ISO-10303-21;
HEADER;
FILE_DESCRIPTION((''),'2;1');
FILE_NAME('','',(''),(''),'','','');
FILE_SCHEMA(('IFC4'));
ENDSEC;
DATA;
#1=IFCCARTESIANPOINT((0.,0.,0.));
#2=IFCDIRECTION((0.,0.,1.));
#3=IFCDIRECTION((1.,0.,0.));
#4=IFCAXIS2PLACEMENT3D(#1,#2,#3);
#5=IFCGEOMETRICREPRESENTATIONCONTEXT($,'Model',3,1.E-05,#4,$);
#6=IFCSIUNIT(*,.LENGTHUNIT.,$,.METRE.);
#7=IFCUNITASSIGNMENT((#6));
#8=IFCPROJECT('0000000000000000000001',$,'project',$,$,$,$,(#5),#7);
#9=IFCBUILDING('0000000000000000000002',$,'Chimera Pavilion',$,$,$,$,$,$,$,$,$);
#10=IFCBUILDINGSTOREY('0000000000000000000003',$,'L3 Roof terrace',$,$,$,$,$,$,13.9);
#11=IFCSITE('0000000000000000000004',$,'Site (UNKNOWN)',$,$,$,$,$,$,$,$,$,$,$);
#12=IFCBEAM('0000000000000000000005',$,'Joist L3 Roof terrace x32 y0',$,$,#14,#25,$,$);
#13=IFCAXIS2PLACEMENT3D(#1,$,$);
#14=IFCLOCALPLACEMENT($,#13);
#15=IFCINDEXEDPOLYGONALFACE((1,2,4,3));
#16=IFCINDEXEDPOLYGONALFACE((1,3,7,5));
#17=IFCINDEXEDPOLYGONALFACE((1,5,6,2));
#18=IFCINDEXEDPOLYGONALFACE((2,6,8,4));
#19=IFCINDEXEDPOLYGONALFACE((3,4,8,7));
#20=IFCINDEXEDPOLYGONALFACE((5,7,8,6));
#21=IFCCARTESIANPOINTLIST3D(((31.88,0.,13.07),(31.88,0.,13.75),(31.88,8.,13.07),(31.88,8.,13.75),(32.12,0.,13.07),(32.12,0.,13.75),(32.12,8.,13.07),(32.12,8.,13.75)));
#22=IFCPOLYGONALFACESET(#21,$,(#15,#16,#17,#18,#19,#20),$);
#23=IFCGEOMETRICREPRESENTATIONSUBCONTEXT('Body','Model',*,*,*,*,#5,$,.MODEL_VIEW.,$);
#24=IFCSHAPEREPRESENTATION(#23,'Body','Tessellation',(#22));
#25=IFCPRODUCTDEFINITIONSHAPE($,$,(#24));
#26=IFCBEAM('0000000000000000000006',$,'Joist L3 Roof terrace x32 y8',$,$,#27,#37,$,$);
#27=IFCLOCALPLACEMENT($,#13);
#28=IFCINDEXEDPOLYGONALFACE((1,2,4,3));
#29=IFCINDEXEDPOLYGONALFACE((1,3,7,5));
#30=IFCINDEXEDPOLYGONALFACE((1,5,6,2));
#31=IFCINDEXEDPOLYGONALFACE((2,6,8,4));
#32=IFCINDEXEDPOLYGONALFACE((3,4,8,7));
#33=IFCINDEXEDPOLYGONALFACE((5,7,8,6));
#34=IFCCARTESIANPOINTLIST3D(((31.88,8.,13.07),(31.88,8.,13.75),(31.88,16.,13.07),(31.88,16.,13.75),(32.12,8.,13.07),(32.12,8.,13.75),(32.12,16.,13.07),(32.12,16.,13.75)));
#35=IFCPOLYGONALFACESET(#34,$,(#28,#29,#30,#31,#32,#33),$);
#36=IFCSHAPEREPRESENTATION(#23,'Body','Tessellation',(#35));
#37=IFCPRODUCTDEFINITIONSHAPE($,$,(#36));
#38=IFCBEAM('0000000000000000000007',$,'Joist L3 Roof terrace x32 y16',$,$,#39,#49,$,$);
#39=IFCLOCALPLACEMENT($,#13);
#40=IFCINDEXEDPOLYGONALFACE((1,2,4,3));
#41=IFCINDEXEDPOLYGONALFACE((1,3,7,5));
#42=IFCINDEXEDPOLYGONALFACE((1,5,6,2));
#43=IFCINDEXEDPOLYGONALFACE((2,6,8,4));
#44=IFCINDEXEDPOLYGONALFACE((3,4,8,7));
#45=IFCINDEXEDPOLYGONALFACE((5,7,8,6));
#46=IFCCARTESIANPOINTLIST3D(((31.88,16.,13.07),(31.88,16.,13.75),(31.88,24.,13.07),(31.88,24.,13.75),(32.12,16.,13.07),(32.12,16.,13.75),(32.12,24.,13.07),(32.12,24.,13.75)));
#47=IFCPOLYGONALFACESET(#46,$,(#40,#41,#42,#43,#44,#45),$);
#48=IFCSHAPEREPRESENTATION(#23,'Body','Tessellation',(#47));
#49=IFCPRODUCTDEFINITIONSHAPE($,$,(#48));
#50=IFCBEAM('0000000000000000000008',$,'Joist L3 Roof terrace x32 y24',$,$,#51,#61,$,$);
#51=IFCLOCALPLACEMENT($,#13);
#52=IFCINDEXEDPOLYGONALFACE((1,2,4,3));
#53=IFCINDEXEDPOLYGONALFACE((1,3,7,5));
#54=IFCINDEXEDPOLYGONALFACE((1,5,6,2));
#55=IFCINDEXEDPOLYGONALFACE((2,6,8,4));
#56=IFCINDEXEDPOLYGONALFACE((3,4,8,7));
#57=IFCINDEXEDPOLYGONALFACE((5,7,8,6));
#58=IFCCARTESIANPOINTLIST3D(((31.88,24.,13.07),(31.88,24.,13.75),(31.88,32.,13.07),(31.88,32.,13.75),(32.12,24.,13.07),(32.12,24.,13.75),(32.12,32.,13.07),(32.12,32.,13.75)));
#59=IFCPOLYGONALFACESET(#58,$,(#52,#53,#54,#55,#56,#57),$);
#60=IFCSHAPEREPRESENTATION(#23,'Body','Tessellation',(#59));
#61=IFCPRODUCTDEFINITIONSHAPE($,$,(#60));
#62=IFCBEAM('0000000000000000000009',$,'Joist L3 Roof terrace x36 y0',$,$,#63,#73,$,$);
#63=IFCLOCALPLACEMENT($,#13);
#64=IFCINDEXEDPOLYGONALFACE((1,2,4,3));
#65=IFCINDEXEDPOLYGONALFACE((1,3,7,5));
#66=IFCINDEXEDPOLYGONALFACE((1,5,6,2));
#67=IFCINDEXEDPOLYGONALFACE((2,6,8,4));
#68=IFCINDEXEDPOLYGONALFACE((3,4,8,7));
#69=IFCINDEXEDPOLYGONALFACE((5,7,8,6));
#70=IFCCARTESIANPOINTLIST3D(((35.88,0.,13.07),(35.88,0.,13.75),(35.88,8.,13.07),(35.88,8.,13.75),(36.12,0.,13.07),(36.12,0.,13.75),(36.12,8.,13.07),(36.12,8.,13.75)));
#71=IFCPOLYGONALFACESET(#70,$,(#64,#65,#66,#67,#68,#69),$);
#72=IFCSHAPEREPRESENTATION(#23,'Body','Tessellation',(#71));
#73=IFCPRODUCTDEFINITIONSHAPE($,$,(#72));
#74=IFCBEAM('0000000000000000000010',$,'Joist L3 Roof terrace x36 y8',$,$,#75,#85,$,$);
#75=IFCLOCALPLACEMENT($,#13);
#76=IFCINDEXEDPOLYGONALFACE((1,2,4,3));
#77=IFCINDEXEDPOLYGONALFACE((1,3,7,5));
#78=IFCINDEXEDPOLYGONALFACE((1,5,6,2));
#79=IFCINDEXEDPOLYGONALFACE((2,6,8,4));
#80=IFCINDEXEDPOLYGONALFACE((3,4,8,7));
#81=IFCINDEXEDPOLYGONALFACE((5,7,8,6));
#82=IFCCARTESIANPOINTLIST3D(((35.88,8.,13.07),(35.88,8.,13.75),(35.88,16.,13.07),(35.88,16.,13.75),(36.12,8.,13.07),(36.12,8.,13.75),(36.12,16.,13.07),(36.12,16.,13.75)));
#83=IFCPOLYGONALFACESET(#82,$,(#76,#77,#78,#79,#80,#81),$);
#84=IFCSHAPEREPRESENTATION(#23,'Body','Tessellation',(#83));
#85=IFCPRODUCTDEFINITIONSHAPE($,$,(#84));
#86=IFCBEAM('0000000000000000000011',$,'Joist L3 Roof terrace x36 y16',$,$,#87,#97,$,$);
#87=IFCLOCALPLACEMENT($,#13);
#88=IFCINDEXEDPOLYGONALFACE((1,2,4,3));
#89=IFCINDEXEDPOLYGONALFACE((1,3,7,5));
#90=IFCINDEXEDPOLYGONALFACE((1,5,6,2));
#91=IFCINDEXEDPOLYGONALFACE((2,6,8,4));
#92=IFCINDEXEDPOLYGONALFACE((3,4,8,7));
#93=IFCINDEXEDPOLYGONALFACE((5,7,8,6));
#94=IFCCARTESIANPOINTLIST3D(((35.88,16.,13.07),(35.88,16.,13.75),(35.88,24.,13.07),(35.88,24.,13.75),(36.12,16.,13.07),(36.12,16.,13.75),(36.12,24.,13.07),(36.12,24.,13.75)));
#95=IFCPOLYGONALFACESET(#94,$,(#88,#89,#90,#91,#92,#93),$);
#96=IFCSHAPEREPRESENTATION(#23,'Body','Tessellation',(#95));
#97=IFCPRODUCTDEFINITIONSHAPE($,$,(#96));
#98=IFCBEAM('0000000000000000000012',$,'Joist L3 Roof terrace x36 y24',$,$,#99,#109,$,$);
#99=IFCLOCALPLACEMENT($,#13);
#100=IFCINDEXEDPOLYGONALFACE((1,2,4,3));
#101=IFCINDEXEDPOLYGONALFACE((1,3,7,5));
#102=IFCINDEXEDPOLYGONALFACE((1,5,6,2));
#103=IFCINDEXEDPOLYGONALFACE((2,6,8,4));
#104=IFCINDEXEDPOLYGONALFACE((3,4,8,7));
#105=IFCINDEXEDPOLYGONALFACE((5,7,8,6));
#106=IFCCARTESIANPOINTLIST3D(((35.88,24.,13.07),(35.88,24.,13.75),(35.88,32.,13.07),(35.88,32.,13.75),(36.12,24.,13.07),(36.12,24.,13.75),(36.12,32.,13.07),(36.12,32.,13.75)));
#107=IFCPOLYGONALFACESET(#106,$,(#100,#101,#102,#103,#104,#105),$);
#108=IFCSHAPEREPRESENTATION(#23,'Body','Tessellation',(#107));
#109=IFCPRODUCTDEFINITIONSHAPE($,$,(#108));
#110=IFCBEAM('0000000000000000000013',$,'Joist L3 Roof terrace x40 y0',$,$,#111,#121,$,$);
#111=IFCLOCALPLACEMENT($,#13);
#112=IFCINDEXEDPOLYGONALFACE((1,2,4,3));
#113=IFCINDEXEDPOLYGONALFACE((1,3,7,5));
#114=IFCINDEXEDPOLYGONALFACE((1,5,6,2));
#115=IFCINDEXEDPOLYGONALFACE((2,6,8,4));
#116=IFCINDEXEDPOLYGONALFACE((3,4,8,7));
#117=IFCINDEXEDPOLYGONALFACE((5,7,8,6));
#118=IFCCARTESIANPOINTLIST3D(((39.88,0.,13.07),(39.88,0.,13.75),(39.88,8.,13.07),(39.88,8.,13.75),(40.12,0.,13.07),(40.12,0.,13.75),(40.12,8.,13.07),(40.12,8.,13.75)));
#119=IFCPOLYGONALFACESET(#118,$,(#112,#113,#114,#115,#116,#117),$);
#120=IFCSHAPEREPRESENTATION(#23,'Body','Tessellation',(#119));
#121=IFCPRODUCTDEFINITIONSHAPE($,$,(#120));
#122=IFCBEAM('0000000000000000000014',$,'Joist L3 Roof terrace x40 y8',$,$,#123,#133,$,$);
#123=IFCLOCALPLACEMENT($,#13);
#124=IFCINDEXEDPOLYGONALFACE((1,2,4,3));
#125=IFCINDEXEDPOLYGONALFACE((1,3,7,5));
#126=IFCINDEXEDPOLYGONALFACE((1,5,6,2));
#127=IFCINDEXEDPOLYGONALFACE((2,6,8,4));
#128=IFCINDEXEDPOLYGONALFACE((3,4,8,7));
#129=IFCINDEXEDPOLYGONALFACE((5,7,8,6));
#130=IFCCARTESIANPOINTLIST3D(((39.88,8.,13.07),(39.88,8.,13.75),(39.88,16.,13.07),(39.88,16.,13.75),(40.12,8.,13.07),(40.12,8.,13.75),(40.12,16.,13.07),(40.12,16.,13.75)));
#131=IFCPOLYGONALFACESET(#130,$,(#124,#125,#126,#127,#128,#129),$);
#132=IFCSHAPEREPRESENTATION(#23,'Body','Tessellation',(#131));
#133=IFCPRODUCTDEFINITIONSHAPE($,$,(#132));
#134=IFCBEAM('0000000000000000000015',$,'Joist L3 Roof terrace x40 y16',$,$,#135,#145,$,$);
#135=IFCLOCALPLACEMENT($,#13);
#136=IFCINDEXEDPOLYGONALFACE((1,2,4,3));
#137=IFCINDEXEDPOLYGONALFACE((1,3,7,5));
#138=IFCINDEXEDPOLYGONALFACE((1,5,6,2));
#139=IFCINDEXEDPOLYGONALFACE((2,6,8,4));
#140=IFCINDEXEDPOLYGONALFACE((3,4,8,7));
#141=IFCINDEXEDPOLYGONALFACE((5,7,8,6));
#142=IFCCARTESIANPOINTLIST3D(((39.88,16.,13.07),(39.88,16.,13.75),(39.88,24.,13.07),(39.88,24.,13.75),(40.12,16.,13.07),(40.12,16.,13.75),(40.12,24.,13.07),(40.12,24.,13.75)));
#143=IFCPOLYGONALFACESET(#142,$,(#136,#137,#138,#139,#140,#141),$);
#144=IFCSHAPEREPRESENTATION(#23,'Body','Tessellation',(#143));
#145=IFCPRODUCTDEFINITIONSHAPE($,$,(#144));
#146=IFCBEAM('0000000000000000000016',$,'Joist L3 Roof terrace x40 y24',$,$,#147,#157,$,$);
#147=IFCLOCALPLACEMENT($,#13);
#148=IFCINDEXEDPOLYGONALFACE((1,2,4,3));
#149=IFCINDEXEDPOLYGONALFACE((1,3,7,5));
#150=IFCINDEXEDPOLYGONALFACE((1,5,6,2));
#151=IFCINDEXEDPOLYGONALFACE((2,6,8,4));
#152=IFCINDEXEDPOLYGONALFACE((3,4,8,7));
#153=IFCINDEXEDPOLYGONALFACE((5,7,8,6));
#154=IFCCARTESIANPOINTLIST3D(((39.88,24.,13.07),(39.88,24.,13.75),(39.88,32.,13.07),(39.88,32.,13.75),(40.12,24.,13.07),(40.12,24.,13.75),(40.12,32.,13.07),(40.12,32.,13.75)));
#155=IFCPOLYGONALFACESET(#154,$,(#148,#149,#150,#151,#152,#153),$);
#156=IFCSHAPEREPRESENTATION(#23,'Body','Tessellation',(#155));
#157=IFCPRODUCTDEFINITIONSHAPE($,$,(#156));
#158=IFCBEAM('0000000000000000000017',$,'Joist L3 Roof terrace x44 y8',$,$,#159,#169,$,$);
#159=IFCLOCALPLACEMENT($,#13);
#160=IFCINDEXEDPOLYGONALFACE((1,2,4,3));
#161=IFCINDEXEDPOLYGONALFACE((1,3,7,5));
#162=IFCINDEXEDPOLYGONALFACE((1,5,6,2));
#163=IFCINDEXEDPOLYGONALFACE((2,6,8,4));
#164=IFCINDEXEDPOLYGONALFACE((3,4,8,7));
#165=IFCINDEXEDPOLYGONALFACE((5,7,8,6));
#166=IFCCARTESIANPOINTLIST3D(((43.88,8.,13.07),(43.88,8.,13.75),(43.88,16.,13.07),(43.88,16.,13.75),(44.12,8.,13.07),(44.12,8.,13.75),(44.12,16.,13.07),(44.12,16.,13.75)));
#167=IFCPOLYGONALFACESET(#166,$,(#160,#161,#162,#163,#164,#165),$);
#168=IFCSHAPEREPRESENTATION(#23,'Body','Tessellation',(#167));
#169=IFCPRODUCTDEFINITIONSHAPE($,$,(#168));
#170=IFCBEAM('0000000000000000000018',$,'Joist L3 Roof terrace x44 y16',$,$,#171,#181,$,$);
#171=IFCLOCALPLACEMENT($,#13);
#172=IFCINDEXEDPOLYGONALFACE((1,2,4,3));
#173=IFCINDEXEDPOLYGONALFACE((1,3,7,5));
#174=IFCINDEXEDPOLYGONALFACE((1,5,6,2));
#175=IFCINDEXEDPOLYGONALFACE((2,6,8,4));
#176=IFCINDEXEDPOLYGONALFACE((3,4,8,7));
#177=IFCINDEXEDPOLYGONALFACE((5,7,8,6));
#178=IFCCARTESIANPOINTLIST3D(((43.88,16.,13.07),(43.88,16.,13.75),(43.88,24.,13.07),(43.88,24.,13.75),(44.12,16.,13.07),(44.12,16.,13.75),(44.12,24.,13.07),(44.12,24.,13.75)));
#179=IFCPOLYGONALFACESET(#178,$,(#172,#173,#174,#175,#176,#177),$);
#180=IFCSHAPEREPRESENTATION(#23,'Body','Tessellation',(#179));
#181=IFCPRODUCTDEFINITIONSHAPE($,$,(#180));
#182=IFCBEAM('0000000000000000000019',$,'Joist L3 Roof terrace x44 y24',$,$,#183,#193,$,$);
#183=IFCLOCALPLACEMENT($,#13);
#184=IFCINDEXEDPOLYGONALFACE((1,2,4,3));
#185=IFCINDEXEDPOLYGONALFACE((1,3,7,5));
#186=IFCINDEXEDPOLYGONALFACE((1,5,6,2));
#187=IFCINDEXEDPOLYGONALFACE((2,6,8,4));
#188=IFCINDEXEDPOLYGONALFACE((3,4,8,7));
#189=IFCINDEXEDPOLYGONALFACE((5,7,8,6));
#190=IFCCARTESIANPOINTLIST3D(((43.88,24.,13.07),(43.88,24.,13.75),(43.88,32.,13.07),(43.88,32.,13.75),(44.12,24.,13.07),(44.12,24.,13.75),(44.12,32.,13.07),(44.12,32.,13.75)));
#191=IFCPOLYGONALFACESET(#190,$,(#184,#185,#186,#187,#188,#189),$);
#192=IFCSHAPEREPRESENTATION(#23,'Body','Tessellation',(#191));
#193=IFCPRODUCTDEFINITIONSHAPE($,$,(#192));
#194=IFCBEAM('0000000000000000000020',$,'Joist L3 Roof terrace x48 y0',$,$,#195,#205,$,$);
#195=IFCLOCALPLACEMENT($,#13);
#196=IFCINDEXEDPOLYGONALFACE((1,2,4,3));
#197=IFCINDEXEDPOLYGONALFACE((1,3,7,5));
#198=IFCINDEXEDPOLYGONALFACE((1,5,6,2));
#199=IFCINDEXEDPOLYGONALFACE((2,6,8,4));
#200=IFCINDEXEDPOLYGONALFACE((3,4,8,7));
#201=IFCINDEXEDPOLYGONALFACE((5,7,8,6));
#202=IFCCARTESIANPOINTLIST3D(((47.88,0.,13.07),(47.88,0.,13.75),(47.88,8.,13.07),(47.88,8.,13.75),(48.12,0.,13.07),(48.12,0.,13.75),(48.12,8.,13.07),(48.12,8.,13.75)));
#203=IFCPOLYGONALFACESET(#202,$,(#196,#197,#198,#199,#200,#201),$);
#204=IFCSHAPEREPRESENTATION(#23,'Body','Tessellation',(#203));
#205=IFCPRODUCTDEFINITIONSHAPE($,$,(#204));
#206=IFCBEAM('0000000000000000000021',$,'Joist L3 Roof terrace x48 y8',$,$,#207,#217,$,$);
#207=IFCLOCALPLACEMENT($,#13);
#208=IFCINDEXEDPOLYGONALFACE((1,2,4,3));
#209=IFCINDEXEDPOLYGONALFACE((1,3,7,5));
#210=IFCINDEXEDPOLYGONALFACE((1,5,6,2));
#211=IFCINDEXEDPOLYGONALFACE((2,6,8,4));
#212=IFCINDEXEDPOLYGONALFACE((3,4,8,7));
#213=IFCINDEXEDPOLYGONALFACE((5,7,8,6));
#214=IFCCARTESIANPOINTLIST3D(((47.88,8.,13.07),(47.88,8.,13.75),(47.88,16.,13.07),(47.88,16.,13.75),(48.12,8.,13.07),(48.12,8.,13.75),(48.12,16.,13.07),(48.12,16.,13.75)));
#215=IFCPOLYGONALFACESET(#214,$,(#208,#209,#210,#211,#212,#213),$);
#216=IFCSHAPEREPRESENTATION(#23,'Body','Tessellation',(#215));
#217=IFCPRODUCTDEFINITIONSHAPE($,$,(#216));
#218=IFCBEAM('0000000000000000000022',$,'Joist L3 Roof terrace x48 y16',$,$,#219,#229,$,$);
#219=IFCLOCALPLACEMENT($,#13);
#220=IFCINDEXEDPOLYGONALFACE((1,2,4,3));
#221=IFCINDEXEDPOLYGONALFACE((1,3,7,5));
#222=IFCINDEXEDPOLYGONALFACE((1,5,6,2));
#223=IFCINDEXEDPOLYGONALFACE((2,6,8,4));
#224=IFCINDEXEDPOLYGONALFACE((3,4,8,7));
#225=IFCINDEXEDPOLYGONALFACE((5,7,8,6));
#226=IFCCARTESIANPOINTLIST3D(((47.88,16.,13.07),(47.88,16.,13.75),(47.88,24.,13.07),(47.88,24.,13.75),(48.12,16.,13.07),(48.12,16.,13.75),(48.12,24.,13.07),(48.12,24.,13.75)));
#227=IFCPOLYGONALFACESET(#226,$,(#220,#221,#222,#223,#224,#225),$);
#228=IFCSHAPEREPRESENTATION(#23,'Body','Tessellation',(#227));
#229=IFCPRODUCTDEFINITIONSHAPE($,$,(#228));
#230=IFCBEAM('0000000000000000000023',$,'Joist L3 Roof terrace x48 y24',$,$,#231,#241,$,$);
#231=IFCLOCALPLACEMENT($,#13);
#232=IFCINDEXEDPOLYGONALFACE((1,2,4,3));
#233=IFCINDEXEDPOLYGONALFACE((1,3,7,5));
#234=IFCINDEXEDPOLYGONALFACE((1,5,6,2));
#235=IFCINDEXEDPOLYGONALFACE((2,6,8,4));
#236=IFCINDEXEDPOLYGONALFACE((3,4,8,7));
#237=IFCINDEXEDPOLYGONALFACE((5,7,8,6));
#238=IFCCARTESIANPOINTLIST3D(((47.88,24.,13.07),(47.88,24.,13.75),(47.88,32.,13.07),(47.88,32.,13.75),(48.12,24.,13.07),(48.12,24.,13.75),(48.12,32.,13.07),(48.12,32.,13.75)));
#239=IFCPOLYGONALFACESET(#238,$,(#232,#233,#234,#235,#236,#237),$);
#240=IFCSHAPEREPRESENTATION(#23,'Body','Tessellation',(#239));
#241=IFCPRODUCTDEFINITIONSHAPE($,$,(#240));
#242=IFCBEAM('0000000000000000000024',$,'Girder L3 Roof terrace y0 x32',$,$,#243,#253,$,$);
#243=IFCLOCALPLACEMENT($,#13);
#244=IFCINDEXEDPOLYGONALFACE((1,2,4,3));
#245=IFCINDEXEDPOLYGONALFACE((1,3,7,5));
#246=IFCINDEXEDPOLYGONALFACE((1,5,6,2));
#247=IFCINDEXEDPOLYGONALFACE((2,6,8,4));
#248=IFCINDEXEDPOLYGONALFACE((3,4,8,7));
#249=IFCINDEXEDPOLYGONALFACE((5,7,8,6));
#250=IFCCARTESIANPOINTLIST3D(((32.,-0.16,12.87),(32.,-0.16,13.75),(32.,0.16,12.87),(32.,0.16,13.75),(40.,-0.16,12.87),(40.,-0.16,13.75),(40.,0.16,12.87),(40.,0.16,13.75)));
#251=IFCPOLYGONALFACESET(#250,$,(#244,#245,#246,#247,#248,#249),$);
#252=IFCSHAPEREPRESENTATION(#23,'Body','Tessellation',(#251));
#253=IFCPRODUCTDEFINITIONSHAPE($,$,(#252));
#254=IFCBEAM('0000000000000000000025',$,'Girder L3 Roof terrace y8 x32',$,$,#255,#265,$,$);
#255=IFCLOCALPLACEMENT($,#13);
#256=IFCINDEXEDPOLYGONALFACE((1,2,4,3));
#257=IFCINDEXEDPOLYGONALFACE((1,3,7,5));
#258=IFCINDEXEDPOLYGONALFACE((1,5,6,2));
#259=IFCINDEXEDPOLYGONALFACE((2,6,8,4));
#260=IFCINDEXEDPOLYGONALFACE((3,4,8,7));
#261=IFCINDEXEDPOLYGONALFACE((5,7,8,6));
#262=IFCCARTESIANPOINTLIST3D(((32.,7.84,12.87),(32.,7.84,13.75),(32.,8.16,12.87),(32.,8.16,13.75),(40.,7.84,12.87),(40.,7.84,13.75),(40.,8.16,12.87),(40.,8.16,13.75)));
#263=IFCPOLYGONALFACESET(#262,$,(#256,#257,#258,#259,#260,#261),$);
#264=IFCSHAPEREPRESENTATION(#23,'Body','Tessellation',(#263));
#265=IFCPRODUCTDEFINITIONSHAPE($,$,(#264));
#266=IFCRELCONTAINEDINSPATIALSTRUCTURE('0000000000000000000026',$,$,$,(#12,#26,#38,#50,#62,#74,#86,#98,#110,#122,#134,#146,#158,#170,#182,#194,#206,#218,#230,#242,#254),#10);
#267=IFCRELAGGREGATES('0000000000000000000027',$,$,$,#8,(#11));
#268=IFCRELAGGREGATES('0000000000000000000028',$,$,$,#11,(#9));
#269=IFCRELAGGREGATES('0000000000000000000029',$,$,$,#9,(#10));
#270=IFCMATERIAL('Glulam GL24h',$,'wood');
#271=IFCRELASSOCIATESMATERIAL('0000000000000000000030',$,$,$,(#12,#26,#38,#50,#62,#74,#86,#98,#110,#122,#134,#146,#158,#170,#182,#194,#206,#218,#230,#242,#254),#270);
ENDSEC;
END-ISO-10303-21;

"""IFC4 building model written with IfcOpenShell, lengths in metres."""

from ifc_helpers import new_model, si_unit, frame, origin_with_axes, place, context, subcontext, project, spatial, rectangle, extrude, material, element, save


model = new_model("IFC4")

# Units and contexts
model_context = context("Model", 3, precision=1e-05, world=origin_with_axes())
body_context = subcontext(model_context, "Body", "Model", "MODEL_VIEW")
ifc_project = project(units=[si_unit("LENGTHUNIT", "METRE")], contexts=[model_context])

# Site, building, storey
site = spatial("IfcSite", under=ifc_project, Name="Site (UNKNOWN)")
building = spatial("IfcBuilding", under=site, Name="Chimera Pavilion")
storey = spatial("IfcBuildingStorey", under=building, Name="L3 Roof terrace", Elevation=13.9)

# Beams
ifc_material_1 = material(Name="Glulam GL24h", Category="wood")
for number, where, z_axis, x_axis, name in (
    (1, (32.0, 0.0, 13.41), (0.0, 1.0, 0.0), (1.0, 0.0, 0.0), "Joist L3 Roof terrace x32 y0"),
    (2, (32.0, 8.0, 13.41), (0.0, 1.0, 0.0), (1.0, 0.0, 0.0), "Joist L3 Roof terrace x32 y8"),
    (3, (32.0, 16.0, 13.41), (0.0, 1.0, 0.0), (1.0, 0.0, 0.0), "Joist L3 Roof terrace x32 y16"),
    (4, (32.0, 24.0, 13.41), (0.0, 1.0, 0.0), (1.0, 0.0, 0.0), "Joist L3 Roof terrace x32 y24"),
    (5, (36.0, 0.0, 13.41), (0.0, 1.0, 0.0), (1.0, 0.0, 0.0), "Joist L3 Roof terrace x36 y0"),
    (6, (36.0, 8.0, 13.41), (0.0, 1.0, 0.0), (1.0, 0.0, 0.0), "Joist L3 Roof terrace x36 y8"),
    (7, (36.0, 16.0, 13.41), (0.0, 1.0, 0.0), (1.0, 0.0, 0.0), "Joist L3 Roof terrace x36 y16"),
    (8, (36.0, 24.0, 13.41), (0.0, 1.0, 0.0), (1.0, 0.0, 0.0), "Joist L3 Roof terrace x36 y24"),
    (9, (40.0, 0.0, 13.41), (0.0, 1.0, 0.0), (1.0, 0.0, 0.0), "Joist L3 Roof terrace x40 y0"),
    (10, (40.0, 8.0, 13.41), (0.0, 1.0, 0.0), (1.0, 0.0, 0.0), "Joist L3 Roof terrace x40 y8"),
    (11, (40.0, 16.0, 13.41), (0.0, 1.0, 0.0), (1.0, 0.0, 0.0), "Joist L3 Roof terrace x40 y16"),
    (12, (40.0, 24.0, 13.41), (0.0, 1.0, 0.0), (1.0, 0.0, 0.0), "Joist L3 Roof terrace x40 y24"),
    (13, (44.0, 8.0, 13.41), (0.0, 1.0, 0.0), (1.0, 0.0, 0.0), "Joist L3 Roof terrace x44 y8"),
    (14, (44.0, 16.0, 13.41), (0.0, 1.0, 0.0), (1.0, 0.0, 0.0), "Joist L3 Roof terrace x44 y16"),
    (15, (44.0, 24.0, 13.41), (0.0, 1.0, 0.0), (1.0, 0.0, 0.0), "Joist L3 Roof terrace x44 y24"),
    (16, (48.0, 0.0, 13.41), (0.0, 1.0, 0.0), (1.0, 0.0, 0.0), "Joist L3 Roof terrace x48 y0"),
    (17, (48.0, 8.0, 13.41), (0.0, 1.0, 0.0), (1.0, 0.0, 0.0), "Joist L3 Roof terrace x48 y8"),
    (18, (48.0, 16.0, 13.41), (0.0, 1.0, 0.0), (1.0, 0.0, 0.0), "Joist L3 Roof terrace x48 y16"),
    (19, (48.0, 24.0, 13.41), (0.0, 1.0, 0.0), (1.0, 0.0, 0.0), "Joist L3 Roof terrace x48 y24"),
):
    element("IfcBeam", number, at=place(None, frame(where, z_axis=z_axis, x_axis=x_axis)), inside=storey, material=ifc_material_1, Name=name, context=body_context, shape_type="SweptSolid", body=[
        extrude(rectangle(XDim=0.24, YDim=0.68), origin_with_axes(), (0.0, 0.0, 1.0), 8.0),
    ])
for number, where, z_axis, x_axis, name in (
    (20, (32.0, 0.0, 13.31), (1.0, 0.0, 0.0), (0.0, -1.0, 0.0), "Girder L3 Roof terrace y0 x32"),
    (21, (32.0, 8.0, 13.31), (1.0, 0.0, 0.0), (0.0, -1.0, 0.0), "Girder L3 Roof terrace y8 x32"),
):
    element("IfcBeam", number, at=place(None, frame(where, z_axis=z_axis, x_axis=x_axis)), inside=storey, material=ifc_material_1, Name=name, context=body_context, shape_type="SweptSolid", body=[
        extrude(rectangle(XDim=0.32, YDim=0.88), origin_with_axes(), (0.0, 0.0, 1.0), 8.0),
    ])

save(model, "model.ifc")
